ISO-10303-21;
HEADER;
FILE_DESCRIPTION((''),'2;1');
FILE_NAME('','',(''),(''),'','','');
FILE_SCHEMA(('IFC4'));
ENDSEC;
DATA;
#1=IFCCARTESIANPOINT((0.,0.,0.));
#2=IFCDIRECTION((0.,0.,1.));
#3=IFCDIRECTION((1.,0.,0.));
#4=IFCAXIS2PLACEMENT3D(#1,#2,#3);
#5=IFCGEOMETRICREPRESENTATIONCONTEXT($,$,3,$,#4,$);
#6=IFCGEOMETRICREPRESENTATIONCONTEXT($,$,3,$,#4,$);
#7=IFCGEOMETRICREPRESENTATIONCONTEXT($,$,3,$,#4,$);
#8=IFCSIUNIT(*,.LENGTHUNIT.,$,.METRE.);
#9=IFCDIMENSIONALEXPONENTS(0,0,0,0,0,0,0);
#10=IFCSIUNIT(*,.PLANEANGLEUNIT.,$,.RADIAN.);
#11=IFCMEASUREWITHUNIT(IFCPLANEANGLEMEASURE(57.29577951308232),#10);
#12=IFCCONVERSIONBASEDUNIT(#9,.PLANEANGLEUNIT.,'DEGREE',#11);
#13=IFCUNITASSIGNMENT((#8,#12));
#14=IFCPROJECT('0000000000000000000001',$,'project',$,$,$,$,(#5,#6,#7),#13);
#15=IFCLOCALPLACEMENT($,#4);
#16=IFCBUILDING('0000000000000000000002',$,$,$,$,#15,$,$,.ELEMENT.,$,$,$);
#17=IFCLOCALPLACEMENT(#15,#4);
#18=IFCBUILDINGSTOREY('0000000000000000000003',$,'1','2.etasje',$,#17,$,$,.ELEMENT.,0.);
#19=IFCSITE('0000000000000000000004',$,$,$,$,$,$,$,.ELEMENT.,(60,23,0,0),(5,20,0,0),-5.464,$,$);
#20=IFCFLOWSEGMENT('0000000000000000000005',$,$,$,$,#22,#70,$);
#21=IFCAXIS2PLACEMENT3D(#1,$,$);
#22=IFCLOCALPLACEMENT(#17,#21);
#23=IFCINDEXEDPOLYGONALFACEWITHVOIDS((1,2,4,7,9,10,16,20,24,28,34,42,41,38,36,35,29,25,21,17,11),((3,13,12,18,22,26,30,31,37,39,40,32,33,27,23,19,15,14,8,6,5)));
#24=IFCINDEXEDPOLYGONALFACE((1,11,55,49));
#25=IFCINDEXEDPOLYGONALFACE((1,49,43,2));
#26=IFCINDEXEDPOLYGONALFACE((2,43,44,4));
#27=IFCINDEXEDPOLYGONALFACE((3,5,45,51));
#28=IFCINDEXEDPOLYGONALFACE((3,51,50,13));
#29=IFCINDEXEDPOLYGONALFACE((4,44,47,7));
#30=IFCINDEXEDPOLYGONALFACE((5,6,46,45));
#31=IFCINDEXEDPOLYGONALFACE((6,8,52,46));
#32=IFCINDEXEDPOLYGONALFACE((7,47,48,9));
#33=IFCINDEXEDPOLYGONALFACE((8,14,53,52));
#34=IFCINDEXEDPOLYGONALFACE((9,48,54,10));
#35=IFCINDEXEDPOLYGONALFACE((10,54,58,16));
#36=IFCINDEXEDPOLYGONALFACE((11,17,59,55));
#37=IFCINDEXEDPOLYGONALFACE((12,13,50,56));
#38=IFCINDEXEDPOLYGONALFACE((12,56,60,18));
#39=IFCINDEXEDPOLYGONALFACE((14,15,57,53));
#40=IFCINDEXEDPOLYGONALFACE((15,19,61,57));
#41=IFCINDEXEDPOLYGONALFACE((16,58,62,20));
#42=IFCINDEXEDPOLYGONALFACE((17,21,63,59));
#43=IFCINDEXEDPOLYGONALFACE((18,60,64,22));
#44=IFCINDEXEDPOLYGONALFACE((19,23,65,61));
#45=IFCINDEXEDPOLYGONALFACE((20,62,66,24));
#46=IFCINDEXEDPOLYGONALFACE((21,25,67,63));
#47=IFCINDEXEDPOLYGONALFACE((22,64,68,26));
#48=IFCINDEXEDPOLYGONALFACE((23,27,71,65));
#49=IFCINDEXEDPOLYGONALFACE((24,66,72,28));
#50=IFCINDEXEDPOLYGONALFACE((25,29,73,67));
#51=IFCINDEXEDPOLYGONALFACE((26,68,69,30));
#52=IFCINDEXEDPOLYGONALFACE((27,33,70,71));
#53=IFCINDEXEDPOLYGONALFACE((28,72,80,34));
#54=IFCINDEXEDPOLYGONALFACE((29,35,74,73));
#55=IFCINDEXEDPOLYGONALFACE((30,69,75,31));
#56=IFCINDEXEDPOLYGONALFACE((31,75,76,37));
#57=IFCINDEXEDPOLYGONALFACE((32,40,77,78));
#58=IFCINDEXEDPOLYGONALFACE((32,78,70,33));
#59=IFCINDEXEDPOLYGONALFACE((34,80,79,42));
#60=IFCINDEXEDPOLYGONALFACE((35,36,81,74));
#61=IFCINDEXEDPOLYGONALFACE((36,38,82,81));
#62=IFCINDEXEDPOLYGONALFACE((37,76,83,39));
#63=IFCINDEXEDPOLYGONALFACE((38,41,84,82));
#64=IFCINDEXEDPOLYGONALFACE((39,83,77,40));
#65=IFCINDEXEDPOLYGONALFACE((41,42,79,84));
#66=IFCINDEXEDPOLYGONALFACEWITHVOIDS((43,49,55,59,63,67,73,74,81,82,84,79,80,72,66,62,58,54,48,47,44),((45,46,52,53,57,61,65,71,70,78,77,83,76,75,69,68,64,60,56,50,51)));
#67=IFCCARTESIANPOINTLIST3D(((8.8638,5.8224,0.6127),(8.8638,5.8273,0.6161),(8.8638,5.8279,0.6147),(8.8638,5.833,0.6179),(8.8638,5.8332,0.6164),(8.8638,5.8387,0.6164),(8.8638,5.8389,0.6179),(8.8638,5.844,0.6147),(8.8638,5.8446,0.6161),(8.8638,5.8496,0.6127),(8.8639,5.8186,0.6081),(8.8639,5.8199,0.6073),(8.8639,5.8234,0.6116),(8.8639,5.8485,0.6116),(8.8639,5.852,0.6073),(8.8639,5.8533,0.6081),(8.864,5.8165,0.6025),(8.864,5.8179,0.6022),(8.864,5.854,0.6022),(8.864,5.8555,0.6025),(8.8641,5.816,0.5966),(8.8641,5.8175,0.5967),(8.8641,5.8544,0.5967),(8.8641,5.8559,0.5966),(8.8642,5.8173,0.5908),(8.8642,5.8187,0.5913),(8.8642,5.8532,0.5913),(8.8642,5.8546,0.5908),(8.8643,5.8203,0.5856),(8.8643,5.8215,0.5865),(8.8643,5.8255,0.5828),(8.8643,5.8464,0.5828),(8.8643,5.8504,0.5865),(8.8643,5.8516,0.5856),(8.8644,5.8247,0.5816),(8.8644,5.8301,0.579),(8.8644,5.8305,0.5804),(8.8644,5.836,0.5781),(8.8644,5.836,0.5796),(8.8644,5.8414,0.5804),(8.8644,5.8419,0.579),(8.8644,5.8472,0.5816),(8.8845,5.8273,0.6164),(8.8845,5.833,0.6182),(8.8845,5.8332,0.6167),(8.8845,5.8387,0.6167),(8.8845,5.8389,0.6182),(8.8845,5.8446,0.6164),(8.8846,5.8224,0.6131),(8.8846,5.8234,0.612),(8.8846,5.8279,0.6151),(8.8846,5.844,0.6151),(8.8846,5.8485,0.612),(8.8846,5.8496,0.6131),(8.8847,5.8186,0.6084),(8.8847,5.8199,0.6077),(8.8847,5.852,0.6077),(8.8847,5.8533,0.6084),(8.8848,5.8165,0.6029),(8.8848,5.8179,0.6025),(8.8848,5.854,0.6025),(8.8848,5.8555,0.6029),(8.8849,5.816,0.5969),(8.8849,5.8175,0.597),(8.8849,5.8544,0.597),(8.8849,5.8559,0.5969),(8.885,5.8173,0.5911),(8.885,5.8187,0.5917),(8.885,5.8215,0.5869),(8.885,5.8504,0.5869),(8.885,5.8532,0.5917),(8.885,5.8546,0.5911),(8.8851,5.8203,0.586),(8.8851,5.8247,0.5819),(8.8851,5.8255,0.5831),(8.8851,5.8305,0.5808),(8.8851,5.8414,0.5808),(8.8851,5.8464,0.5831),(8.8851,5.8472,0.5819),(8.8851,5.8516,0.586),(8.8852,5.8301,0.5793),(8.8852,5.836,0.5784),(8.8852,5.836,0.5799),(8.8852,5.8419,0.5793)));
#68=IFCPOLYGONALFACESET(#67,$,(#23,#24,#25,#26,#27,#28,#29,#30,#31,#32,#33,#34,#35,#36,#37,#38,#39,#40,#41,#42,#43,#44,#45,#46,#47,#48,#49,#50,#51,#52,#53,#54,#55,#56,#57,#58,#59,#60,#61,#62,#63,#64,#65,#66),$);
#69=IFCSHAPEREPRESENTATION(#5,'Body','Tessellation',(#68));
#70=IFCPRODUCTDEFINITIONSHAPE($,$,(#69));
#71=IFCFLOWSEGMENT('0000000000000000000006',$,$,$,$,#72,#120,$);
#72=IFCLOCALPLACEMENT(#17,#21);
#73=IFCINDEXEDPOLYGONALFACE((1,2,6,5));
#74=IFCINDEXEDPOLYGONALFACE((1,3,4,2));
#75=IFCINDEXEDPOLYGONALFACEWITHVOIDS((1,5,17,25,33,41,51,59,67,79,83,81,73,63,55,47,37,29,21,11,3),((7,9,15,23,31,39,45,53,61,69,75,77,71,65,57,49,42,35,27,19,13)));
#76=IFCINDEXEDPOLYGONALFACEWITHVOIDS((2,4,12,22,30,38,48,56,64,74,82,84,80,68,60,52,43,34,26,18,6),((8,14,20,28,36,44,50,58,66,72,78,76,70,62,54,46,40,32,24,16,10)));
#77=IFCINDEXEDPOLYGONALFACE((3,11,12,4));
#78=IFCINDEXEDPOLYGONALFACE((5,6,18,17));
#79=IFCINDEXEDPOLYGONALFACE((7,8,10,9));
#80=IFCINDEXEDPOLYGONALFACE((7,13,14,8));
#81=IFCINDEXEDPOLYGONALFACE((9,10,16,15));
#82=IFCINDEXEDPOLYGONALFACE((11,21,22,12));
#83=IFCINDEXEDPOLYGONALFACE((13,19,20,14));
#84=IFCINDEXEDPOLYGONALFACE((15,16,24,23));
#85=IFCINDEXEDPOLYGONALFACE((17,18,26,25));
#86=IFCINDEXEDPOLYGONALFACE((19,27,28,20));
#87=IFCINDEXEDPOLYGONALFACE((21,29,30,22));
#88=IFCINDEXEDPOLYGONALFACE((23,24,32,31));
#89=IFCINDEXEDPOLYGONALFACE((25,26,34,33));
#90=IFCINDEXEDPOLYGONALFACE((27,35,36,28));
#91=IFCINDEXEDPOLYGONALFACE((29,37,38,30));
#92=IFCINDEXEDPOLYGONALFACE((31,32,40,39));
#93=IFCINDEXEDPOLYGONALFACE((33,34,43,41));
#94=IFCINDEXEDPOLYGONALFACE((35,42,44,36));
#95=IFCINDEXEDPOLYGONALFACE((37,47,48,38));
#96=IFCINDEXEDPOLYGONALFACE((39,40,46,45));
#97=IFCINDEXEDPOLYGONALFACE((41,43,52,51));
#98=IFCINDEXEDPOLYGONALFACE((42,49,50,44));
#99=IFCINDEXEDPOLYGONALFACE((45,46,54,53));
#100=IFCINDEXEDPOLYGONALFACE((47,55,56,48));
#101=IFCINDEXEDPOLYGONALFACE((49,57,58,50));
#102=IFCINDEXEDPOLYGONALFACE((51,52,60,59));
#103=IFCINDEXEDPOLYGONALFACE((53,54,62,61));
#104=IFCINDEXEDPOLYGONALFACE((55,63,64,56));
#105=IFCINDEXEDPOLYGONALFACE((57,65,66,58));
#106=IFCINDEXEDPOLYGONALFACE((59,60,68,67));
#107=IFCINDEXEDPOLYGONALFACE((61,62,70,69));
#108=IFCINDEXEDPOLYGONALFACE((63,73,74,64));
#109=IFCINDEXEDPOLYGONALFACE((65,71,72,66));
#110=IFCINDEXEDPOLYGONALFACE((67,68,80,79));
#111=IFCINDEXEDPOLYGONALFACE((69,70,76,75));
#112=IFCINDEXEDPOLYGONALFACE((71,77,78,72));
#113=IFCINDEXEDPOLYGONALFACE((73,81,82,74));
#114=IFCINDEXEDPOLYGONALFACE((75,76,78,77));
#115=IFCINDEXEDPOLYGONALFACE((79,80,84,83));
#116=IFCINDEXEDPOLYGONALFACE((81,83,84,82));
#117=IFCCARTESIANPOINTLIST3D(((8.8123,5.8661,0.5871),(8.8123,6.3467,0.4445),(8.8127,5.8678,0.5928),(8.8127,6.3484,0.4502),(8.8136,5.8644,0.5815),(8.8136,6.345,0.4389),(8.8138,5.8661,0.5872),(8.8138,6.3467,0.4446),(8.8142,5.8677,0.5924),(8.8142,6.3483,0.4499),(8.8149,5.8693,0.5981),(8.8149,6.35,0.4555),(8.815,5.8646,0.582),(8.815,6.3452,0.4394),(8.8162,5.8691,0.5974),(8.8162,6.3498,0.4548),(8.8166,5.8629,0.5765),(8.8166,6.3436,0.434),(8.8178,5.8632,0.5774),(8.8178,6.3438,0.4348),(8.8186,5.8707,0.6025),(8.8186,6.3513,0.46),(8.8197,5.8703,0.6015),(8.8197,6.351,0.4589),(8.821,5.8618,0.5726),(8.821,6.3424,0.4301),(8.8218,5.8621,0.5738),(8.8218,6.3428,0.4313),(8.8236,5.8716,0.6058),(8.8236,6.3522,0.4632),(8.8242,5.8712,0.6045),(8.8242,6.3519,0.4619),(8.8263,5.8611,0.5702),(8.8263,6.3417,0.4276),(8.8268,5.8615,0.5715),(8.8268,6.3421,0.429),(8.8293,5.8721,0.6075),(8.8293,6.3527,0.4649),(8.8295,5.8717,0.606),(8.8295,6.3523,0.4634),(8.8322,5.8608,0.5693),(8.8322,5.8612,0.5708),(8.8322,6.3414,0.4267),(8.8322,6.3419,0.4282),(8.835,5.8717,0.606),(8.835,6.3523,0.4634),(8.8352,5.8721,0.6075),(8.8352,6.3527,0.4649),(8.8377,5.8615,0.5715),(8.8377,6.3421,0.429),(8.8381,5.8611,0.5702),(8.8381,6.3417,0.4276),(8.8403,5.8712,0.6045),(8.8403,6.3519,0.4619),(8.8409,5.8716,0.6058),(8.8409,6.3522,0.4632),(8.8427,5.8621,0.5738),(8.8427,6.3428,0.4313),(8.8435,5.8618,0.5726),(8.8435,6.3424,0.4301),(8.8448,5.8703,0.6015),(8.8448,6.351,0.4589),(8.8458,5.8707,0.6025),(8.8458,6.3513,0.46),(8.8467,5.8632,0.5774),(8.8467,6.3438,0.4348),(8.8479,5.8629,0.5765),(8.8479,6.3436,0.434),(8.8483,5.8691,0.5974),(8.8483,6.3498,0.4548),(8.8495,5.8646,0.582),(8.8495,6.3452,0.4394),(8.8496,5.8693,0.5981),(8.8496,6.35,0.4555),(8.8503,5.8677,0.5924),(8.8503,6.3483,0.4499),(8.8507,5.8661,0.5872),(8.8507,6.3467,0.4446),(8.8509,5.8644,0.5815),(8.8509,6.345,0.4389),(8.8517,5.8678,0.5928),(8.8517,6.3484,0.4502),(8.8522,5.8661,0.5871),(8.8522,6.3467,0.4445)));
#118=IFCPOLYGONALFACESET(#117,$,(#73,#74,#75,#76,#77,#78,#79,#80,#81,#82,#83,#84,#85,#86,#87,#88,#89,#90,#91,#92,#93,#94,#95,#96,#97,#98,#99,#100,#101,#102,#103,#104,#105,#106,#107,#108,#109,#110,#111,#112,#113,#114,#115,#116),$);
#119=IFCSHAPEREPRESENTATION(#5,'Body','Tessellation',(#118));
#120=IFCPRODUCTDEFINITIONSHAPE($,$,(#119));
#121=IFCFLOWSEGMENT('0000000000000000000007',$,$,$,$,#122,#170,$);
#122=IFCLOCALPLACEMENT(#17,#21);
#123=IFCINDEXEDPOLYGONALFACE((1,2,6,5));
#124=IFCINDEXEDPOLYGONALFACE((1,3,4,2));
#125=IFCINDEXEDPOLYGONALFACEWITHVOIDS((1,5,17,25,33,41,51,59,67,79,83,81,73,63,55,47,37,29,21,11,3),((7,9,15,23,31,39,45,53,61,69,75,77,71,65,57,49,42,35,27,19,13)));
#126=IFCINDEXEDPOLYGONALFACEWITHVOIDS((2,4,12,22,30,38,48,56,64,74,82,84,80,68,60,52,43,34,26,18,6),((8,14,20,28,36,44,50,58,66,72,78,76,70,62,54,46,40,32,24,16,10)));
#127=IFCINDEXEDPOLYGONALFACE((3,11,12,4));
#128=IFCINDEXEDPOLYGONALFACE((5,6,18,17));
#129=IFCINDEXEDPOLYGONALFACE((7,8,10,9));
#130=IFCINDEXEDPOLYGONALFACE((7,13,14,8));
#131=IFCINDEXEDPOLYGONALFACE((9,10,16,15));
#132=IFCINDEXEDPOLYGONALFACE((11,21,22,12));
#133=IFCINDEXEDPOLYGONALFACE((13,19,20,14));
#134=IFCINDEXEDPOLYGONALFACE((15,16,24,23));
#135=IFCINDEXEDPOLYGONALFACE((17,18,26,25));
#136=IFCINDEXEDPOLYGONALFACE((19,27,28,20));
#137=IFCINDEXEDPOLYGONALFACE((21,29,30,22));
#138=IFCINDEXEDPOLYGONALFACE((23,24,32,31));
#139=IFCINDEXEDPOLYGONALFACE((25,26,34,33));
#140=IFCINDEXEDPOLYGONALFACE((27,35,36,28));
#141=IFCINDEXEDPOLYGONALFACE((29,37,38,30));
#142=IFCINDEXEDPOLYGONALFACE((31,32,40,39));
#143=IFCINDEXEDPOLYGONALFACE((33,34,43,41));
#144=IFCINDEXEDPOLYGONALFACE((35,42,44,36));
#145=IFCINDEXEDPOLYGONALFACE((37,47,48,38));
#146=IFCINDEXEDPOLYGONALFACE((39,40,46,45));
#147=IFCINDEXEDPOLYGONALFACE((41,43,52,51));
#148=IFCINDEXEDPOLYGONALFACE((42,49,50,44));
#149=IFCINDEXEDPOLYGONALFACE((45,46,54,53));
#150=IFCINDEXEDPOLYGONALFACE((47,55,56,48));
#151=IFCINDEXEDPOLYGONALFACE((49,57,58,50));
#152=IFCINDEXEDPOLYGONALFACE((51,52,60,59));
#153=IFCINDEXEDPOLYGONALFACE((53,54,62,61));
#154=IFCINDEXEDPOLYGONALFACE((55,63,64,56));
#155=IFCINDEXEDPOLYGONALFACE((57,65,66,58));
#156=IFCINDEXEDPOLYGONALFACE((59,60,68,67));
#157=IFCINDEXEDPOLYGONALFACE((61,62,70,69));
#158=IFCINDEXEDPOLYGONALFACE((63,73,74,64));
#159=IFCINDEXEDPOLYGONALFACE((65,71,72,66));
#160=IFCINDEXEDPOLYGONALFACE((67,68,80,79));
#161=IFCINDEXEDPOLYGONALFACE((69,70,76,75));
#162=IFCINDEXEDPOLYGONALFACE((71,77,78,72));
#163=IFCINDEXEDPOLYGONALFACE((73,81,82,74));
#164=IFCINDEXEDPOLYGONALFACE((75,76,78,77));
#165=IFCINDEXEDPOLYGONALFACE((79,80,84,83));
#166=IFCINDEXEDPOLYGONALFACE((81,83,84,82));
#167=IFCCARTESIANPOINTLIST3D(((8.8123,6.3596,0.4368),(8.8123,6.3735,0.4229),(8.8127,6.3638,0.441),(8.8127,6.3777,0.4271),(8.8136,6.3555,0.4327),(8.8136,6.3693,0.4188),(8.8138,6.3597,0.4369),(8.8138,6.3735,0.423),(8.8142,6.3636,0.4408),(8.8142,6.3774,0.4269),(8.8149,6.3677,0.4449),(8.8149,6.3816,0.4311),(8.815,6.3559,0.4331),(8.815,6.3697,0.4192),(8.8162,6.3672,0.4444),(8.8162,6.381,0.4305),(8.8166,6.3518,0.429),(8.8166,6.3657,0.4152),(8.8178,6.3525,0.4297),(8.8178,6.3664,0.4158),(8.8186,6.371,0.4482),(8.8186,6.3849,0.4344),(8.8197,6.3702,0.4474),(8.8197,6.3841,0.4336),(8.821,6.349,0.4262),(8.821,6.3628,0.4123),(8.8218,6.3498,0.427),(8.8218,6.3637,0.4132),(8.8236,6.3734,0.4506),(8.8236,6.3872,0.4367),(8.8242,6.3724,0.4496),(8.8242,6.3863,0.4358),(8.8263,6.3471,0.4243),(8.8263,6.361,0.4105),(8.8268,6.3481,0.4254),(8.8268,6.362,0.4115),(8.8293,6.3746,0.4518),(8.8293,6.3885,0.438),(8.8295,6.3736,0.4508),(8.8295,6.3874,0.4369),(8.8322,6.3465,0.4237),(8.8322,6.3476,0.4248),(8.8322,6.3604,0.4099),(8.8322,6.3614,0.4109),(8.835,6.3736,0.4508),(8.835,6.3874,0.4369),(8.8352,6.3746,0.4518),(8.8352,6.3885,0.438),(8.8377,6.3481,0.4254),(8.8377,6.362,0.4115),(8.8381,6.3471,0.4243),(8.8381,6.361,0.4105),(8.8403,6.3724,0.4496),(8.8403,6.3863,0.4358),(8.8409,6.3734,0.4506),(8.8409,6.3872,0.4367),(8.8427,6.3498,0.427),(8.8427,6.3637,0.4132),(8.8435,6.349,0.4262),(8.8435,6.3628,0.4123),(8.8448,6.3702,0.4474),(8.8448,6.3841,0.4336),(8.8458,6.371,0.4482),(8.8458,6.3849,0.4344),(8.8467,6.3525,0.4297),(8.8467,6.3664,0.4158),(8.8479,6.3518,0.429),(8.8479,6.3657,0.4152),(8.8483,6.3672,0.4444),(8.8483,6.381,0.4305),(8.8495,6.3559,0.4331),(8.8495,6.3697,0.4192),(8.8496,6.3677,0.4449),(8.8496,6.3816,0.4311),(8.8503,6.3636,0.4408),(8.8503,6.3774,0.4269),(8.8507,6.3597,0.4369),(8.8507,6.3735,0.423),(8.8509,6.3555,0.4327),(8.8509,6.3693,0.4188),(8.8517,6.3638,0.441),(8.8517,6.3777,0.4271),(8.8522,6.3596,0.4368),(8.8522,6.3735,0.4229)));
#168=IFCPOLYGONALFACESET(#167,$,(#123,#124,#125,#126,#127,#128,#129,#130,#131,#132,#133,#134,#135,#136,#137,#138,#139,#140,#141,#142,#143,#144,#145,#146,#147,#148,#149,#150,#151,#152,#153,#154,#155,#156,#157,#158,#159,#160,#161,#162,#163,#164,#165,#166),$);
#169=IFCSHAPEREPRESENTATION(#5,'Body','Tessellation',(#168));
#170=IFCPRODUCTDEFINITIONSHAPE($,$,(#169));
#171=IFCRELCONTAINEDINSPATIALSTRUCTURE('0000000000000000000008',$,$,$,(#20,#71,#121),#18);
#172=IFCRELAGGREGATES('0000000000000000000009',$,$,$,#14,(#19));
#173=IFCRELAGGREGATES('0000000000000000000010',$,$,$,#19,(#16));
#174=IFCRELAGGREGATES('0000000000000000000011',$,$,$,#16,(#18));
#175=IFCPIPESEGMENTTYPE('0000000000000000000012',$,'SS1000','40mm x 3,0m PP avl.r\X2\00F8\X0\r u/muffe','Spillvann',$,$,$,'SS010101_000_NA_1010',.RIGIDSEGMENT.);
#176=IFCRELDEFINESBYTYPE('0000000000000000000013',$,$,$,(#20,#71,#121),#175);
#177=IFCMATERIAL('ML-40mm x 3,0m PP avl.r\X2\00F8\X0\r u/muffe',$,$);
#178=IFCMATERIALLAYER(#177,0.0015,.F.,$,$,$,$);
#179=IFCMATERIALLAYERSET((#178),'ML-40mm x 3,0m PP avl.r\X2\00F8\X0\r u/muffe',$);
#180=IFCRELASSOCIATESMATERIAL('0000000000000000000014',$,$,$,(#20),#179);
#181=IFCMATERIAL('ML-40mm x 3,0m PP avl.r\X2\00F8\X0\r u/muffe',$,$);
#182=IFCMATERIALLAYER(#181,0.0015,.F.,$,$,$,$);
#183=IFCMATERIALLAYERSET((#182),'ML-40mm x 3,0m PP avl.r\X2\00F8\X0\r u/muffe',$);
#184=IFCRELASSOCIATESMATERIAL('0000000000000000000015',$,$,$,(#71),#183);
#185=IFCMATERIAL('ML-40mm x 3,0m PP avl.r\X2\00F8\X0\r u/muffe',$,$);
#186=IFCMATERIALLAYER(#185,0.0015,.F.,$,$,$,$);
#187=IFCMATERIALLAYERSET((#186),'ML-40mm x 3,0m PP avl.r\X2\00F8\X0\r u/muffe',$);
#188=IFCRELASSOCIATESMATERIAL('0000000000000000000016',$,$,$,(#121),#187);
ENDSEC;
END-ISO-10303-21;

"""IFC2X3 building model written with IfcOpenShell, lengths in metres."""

from ifc_helpers import new_model, entity, si_unit, converted_unit, frame, origin_with_axes, origin_2d_with_axis, place, context, project, spatial, hollow_circle, extrude, material, layer, layer_set, layer_usage, type_object, element, save


model = new_model("IFC2X3")

# Units and contexts
context_of_model_1 = context(None, 3, world=origin_with_axes())
context_of_model_2 = context(None, 3, world=origin_with_axes())
context_of_model_3 = context(None, 3, world=origin_with_axes())
ifc_project = project(units=[si_unit("LENGTHUNIT", "METRE"), converted_unit("PLANEANGLEUNIT", "DEGREE", entity("IfcPlaneAngleMeasure", 57.29577951308232), si_unit("PLANEANGLEUNIT", "RADIAN"), dimensions=[0, 0, 0, 0, 0, 0, 0])], contexts=[context_of_model_1, context_of_model_2, context_of_model_3])

# Site, building, storey
site = spatial("IfcSite", under=ifc_project, CompositionType="ELEMENT", RefLatitude=(60, 23, 0, 0), RefLongitude=(5, 20, 0, 0), RefElevation=-5.464)
building_placement = place(None, origin_with_axes())
building = spatial("IfcBuilding", under=site, at=building_placement, CompositionType="ELEMENT")
storey_placement = place(building_placement, origin_with_axes())
storey = spatial("IfcBuildingStorey", under=building, at=storey_placement, Name="1", Description="2.etasje", CompositionType="ELEMENT", Elevation=0.0)

# Flow segments
ifc_material_1 = material(Name="ML-40mm x 3,0m PP avl.rør u/muffe")
ifc_layer_1 = layer(ifc_material_1, 0.0015, ventilated=False)
ifc_layer_set_1 = layer_set([ifc_layer_1], Name="ML-40mm x 3,0m PP avl.rør u/muffe")
ifc_layer_usage_1 = layer_usage(ifc_layer_set_1, "AXIS2", "POSITIVE", 0.0)
pipe_segment_type_1 = type_object("IfcPipeSegmentType", Name="SS1000", Description="40mm x 3,0m PP avl.rør u/muffe", ApplicableOccurrence="Spillvann", ElementType="SS010101_000_NA_1010", PredefinedType="RIGIDSEGMENT")
flow_segment_1_placement = place(storey_placement, frame((8.8848, 5.836, 0.5984), z_axis=(-0.999861, 0.0, -0.016664), x_axis=(0.016664, 0.0, -0.999861)))
element("IfcFlowSegment", 1, at=flow_segment_1_placement, inside=storey, type_object=pipe_segment_type_1, material=ifc_layer_usage_1, context=context_of_model_1, shape_type="SweptSolid", body=[
    extrude(hollow_circle(Radius=0.02, WallThickness=0.0015, at=origin_2d_with_axis()), origin_with_axes(), (0.0, 0.0, 1.0), 0.0208),
])
ifc_material_2 = material(Name="ML-40mm x 3,0m PP avl.rør u/muffe")
ifc_layer_2 = layer(ifc_material_2, 0.0015, ventilated=False)
ifc_layer_set_2 = layer_set([ifc_layer_2], Name="ML-40mm x 3,0m PP avl.rør u/muffe")
ifc_layer_usage_2 = layer_usage(ifc_layer_set_2, "AXIS2", "POSITIVE", 0.0)
flow_segment_2_placement = place(storey_placement, frame((8.8322, 5.8665, 0.5885), z_axis=(0.0, 0.958702, -0.284414), x_axis=(0.0, -0.284414, -0.958702)))
element("IfcFlowSegment", 2, at=flow_segment_2_placement, inside=storey, type_object=pipe_segment_type_1, material=ifc_layer_usage_2, context=context_of_model_1, shape_type="SweptSolid", body=[
    extrude(hollow_circle(Radius=0.02, WallThickness=0.0015, at=origin_2d_with_axis()), origin_with_axes(), (0.0, 0.0, 1.0), 0.5013),
])
ifc_material_3 = material(Name="ML-40mm x 3,0m PP avl.rør u/muffe")
ifc_layer_3 = layer(ifc_material_3, 0.0015, ventilated=False)
ifc_layer_set_3 = layer_set([ifc_layer_3], Name="ML-40mm x 3,0m PP avl.rør u/muffe")
ifc_layer_usage_3 = layer_usage(ifc_layer_set_3, "AXIS2", "POSITIVE", 0.0)
flow_segment_3_placement = place(storey_placement, frame((8.8322, 6.3606, 0.4379), z_axis=(0.0, 0.707107, -0.707107), x_axis=(0.0, -0.707107, -0.707107)))
element("IfcFlowSegment", 3, at=flow_segment_3_placement, inside=storey, type_object=pipe_segment_type_1, material=ifc_layer_usage_3, context=context_of_model_1, shape_type="SweptSolid", body=[
    extrude(hollow_circle(Radius=0.02, WallThickness=0.0015, at=origin_2d_with_axis()), origin_with_axes(), (0.0, 0.0, 1.0), 0.0196),
])

save(model, "model.ifc")
